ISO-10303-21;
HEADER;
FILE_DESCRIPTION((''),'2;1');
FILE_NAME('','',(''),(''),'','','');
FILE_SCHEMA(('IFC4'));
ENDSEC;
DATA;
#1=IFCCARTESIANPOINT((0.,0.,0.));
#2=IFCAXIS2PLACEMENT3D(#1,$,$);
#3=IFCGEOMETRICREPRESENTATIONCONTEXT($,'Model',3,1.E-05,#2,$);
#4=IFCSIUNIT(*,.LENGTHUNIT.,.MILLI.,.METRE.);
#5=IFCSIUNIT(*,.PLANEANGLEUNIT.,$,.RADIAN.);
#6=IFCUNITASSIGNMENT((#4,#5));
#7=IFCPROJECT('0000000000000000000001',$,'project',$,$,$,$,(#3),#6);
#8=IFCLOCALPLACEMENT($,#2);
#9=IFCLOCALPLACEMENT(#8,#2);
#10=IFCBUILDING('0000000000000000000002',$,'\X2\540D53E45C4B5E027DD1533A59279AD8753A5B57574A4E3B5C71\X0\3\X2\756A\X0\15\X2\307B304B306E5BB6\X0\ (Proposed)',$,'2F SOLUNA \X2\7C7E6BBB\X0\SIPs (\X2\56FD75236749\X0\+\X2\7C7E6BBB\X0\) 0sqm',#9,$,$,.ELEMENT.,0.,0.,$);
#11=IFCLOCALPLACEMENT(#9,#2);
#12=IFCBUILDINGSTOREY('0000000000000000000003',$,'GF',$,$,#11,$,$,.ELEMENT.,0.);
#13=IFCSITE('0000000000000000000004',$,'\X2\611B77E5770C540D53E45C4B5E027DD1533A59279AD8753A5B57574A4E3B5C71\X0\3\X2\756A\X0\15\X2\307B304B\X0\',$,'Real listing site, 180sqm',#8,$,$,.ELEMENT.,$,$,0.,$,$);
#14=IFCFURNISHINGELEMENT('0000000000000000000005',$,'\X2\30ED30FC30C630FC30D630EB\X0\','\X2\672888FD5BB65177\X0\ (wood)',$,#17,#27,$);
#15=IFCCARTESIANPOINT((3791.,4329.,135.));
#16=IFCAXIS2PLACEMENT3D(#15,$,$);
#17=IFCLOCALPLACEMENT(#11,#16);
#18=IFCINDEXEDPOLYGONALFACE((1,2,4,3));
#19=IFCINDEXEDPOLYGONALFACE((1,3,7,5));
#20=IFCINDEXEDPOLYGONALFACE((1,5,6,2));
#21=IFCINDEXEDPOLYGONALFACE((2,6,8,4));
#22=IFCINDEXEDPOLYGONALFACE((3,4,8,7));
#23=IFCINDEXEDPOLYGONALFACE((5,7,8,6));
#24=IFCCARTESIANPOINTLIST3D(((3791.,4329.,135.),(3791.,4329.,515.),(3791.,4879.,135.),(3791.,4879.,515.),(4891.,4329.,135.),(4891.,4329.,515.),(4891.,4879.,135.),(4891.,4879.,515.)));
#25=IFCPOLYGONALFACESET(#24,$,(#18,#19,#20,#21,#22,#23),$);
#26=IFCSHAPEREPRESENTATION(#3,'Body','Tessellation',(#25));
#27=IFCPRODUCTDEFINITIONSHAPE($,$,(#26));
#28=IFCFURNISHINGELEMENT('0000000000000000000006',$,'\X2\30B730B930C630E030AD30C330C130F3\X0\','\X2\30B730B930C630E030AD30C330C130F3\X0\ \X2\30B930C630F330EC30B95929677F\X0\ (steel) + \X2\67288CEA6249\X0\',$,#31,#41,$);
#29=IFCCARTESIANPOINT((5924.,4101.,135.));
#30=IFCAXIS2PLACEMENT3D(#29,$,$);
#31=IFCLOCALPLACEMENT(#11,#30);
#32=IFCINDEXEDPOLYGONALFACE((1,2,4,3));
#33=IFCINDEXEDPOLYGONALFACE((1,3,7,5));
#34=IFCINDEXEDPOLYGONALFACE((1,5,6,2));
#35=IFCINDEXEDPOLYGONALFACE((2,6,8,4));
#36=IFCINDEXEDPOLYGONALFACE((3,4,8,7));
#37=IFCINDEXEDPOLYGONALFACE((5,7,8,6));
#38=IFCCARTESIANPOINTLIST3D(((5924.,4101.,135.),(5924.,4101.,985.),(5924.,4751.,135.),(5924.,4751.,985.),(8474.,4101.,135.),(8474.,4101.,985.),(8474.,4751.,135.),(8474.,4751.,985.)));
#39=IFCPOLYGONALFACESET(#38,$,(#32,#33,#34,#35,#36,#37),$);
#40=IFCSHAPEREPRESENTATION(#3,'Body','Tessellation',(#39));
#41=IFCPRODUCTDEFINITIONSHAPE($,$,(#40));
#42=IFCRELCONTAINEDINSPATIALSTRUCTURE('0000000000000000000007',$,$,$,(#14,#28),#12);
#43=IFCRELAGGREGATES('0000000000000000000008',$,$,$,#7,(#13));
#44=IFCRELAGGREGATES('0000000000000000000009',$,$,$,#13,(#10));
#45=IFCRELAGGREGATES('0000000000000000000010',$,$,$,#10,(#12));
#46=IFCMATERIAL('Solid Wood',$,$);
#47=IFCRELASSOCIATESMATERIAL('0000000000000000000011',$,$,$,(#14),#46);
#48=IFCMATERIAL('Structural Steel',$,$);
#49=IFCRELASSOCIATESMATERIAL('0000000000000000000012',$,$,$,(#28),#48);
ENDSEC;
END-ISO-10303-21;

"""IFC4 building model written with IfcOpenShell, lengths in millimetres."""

from ifc_helpers import new_model, si_unit, frame, frame_2d, origin, place, context, project, spatial, rectangle, extrude, material, element, save


model = new_model("IFC4")

# Units and contexts
model_context = context("Model", 3, precision=1e-05, world=origin())
ifc_project = project(units=[si_unit("LENGTHUNIT", "METRE", prefix="MILLI"), si_unit("PLANEANGLEUNIT", "RADIAN")], contexts=[model_context])

# Site, building, storey
site_placement = place(None, origin())
site = spatial("IfcSite", under=ifc_project, at=site_placement, Name="愛知県名古屋市緑区大高町字坊主山3番15ほか", ObjectType="Real listing site, 180sqm", CompositionType="ELEMENT", RefElevation=0.0)
building_placement = place(site_placement, origin())
building = spatial("IfcBuilding", under=site, at=building_placement, Name="名古屋市緑区大高町字坊主山3番15ほかの家 (Proposed)", ObjectType="2F SOLUNA 籾殻SIPs (国産杉+籾殻) 0sqm", CompositionType="ELEMENT", ElevationOfRefHeight=0.0, ElevationOfTerrain=0.0)
storey_placement = place(building_placement, origin())
storey = spatial("IfcBuildingStorey", under=building, at=storey_placement, Name="GF", CompositionType="ELEMENT", Elevation=0.0)

# Shared definitions
ifc_material_1 = material(Name="Solid Wood")

# Furnishing elements
furnishing_1_placement = place(storey_placement, frame((3791.0, 4329.0, 135.0)))
element("IfcFurnishingElement", 1, at=furnishing_1_placement, inside=storey, material=ifc_material_1, Name="ローテーブル", Description="木製家具 (wood)", context=model_context, shape_type="SweptSolid", body=[
    extrude(rectangle(XDim=1100.0, YDim=550.0, at=frame_2d((550.0, 275.0))), frame((3791.0, 4329.0, 135.0)), (0.0, 0.0, 1.0), 380.0),
])
ifc_material_2 = material(Name="Structural Steel")
furnishing_2_placement = place(storey_placement, frame((5924.0, 4101.0, 135.0)))
element("IfcFurnishingElement", 2, at=furnishing_2_placement, inside=storey, material=ifc_material_2, Name="システムキッチン", Description="システムキッチン ステンレス天板 (steel) + 木質扉", context=model_context, shape_type="SweptSolid", body=[
    extrude(rectangle(XDim=2550.0, YDim=650.0, at=frame_2d((1275.0, 325.0))), frame((5924.0, 4101.0, 135.0)), (0.0, 0.0, 1.0), 850.0),
])

save(model, "model.ifc")
